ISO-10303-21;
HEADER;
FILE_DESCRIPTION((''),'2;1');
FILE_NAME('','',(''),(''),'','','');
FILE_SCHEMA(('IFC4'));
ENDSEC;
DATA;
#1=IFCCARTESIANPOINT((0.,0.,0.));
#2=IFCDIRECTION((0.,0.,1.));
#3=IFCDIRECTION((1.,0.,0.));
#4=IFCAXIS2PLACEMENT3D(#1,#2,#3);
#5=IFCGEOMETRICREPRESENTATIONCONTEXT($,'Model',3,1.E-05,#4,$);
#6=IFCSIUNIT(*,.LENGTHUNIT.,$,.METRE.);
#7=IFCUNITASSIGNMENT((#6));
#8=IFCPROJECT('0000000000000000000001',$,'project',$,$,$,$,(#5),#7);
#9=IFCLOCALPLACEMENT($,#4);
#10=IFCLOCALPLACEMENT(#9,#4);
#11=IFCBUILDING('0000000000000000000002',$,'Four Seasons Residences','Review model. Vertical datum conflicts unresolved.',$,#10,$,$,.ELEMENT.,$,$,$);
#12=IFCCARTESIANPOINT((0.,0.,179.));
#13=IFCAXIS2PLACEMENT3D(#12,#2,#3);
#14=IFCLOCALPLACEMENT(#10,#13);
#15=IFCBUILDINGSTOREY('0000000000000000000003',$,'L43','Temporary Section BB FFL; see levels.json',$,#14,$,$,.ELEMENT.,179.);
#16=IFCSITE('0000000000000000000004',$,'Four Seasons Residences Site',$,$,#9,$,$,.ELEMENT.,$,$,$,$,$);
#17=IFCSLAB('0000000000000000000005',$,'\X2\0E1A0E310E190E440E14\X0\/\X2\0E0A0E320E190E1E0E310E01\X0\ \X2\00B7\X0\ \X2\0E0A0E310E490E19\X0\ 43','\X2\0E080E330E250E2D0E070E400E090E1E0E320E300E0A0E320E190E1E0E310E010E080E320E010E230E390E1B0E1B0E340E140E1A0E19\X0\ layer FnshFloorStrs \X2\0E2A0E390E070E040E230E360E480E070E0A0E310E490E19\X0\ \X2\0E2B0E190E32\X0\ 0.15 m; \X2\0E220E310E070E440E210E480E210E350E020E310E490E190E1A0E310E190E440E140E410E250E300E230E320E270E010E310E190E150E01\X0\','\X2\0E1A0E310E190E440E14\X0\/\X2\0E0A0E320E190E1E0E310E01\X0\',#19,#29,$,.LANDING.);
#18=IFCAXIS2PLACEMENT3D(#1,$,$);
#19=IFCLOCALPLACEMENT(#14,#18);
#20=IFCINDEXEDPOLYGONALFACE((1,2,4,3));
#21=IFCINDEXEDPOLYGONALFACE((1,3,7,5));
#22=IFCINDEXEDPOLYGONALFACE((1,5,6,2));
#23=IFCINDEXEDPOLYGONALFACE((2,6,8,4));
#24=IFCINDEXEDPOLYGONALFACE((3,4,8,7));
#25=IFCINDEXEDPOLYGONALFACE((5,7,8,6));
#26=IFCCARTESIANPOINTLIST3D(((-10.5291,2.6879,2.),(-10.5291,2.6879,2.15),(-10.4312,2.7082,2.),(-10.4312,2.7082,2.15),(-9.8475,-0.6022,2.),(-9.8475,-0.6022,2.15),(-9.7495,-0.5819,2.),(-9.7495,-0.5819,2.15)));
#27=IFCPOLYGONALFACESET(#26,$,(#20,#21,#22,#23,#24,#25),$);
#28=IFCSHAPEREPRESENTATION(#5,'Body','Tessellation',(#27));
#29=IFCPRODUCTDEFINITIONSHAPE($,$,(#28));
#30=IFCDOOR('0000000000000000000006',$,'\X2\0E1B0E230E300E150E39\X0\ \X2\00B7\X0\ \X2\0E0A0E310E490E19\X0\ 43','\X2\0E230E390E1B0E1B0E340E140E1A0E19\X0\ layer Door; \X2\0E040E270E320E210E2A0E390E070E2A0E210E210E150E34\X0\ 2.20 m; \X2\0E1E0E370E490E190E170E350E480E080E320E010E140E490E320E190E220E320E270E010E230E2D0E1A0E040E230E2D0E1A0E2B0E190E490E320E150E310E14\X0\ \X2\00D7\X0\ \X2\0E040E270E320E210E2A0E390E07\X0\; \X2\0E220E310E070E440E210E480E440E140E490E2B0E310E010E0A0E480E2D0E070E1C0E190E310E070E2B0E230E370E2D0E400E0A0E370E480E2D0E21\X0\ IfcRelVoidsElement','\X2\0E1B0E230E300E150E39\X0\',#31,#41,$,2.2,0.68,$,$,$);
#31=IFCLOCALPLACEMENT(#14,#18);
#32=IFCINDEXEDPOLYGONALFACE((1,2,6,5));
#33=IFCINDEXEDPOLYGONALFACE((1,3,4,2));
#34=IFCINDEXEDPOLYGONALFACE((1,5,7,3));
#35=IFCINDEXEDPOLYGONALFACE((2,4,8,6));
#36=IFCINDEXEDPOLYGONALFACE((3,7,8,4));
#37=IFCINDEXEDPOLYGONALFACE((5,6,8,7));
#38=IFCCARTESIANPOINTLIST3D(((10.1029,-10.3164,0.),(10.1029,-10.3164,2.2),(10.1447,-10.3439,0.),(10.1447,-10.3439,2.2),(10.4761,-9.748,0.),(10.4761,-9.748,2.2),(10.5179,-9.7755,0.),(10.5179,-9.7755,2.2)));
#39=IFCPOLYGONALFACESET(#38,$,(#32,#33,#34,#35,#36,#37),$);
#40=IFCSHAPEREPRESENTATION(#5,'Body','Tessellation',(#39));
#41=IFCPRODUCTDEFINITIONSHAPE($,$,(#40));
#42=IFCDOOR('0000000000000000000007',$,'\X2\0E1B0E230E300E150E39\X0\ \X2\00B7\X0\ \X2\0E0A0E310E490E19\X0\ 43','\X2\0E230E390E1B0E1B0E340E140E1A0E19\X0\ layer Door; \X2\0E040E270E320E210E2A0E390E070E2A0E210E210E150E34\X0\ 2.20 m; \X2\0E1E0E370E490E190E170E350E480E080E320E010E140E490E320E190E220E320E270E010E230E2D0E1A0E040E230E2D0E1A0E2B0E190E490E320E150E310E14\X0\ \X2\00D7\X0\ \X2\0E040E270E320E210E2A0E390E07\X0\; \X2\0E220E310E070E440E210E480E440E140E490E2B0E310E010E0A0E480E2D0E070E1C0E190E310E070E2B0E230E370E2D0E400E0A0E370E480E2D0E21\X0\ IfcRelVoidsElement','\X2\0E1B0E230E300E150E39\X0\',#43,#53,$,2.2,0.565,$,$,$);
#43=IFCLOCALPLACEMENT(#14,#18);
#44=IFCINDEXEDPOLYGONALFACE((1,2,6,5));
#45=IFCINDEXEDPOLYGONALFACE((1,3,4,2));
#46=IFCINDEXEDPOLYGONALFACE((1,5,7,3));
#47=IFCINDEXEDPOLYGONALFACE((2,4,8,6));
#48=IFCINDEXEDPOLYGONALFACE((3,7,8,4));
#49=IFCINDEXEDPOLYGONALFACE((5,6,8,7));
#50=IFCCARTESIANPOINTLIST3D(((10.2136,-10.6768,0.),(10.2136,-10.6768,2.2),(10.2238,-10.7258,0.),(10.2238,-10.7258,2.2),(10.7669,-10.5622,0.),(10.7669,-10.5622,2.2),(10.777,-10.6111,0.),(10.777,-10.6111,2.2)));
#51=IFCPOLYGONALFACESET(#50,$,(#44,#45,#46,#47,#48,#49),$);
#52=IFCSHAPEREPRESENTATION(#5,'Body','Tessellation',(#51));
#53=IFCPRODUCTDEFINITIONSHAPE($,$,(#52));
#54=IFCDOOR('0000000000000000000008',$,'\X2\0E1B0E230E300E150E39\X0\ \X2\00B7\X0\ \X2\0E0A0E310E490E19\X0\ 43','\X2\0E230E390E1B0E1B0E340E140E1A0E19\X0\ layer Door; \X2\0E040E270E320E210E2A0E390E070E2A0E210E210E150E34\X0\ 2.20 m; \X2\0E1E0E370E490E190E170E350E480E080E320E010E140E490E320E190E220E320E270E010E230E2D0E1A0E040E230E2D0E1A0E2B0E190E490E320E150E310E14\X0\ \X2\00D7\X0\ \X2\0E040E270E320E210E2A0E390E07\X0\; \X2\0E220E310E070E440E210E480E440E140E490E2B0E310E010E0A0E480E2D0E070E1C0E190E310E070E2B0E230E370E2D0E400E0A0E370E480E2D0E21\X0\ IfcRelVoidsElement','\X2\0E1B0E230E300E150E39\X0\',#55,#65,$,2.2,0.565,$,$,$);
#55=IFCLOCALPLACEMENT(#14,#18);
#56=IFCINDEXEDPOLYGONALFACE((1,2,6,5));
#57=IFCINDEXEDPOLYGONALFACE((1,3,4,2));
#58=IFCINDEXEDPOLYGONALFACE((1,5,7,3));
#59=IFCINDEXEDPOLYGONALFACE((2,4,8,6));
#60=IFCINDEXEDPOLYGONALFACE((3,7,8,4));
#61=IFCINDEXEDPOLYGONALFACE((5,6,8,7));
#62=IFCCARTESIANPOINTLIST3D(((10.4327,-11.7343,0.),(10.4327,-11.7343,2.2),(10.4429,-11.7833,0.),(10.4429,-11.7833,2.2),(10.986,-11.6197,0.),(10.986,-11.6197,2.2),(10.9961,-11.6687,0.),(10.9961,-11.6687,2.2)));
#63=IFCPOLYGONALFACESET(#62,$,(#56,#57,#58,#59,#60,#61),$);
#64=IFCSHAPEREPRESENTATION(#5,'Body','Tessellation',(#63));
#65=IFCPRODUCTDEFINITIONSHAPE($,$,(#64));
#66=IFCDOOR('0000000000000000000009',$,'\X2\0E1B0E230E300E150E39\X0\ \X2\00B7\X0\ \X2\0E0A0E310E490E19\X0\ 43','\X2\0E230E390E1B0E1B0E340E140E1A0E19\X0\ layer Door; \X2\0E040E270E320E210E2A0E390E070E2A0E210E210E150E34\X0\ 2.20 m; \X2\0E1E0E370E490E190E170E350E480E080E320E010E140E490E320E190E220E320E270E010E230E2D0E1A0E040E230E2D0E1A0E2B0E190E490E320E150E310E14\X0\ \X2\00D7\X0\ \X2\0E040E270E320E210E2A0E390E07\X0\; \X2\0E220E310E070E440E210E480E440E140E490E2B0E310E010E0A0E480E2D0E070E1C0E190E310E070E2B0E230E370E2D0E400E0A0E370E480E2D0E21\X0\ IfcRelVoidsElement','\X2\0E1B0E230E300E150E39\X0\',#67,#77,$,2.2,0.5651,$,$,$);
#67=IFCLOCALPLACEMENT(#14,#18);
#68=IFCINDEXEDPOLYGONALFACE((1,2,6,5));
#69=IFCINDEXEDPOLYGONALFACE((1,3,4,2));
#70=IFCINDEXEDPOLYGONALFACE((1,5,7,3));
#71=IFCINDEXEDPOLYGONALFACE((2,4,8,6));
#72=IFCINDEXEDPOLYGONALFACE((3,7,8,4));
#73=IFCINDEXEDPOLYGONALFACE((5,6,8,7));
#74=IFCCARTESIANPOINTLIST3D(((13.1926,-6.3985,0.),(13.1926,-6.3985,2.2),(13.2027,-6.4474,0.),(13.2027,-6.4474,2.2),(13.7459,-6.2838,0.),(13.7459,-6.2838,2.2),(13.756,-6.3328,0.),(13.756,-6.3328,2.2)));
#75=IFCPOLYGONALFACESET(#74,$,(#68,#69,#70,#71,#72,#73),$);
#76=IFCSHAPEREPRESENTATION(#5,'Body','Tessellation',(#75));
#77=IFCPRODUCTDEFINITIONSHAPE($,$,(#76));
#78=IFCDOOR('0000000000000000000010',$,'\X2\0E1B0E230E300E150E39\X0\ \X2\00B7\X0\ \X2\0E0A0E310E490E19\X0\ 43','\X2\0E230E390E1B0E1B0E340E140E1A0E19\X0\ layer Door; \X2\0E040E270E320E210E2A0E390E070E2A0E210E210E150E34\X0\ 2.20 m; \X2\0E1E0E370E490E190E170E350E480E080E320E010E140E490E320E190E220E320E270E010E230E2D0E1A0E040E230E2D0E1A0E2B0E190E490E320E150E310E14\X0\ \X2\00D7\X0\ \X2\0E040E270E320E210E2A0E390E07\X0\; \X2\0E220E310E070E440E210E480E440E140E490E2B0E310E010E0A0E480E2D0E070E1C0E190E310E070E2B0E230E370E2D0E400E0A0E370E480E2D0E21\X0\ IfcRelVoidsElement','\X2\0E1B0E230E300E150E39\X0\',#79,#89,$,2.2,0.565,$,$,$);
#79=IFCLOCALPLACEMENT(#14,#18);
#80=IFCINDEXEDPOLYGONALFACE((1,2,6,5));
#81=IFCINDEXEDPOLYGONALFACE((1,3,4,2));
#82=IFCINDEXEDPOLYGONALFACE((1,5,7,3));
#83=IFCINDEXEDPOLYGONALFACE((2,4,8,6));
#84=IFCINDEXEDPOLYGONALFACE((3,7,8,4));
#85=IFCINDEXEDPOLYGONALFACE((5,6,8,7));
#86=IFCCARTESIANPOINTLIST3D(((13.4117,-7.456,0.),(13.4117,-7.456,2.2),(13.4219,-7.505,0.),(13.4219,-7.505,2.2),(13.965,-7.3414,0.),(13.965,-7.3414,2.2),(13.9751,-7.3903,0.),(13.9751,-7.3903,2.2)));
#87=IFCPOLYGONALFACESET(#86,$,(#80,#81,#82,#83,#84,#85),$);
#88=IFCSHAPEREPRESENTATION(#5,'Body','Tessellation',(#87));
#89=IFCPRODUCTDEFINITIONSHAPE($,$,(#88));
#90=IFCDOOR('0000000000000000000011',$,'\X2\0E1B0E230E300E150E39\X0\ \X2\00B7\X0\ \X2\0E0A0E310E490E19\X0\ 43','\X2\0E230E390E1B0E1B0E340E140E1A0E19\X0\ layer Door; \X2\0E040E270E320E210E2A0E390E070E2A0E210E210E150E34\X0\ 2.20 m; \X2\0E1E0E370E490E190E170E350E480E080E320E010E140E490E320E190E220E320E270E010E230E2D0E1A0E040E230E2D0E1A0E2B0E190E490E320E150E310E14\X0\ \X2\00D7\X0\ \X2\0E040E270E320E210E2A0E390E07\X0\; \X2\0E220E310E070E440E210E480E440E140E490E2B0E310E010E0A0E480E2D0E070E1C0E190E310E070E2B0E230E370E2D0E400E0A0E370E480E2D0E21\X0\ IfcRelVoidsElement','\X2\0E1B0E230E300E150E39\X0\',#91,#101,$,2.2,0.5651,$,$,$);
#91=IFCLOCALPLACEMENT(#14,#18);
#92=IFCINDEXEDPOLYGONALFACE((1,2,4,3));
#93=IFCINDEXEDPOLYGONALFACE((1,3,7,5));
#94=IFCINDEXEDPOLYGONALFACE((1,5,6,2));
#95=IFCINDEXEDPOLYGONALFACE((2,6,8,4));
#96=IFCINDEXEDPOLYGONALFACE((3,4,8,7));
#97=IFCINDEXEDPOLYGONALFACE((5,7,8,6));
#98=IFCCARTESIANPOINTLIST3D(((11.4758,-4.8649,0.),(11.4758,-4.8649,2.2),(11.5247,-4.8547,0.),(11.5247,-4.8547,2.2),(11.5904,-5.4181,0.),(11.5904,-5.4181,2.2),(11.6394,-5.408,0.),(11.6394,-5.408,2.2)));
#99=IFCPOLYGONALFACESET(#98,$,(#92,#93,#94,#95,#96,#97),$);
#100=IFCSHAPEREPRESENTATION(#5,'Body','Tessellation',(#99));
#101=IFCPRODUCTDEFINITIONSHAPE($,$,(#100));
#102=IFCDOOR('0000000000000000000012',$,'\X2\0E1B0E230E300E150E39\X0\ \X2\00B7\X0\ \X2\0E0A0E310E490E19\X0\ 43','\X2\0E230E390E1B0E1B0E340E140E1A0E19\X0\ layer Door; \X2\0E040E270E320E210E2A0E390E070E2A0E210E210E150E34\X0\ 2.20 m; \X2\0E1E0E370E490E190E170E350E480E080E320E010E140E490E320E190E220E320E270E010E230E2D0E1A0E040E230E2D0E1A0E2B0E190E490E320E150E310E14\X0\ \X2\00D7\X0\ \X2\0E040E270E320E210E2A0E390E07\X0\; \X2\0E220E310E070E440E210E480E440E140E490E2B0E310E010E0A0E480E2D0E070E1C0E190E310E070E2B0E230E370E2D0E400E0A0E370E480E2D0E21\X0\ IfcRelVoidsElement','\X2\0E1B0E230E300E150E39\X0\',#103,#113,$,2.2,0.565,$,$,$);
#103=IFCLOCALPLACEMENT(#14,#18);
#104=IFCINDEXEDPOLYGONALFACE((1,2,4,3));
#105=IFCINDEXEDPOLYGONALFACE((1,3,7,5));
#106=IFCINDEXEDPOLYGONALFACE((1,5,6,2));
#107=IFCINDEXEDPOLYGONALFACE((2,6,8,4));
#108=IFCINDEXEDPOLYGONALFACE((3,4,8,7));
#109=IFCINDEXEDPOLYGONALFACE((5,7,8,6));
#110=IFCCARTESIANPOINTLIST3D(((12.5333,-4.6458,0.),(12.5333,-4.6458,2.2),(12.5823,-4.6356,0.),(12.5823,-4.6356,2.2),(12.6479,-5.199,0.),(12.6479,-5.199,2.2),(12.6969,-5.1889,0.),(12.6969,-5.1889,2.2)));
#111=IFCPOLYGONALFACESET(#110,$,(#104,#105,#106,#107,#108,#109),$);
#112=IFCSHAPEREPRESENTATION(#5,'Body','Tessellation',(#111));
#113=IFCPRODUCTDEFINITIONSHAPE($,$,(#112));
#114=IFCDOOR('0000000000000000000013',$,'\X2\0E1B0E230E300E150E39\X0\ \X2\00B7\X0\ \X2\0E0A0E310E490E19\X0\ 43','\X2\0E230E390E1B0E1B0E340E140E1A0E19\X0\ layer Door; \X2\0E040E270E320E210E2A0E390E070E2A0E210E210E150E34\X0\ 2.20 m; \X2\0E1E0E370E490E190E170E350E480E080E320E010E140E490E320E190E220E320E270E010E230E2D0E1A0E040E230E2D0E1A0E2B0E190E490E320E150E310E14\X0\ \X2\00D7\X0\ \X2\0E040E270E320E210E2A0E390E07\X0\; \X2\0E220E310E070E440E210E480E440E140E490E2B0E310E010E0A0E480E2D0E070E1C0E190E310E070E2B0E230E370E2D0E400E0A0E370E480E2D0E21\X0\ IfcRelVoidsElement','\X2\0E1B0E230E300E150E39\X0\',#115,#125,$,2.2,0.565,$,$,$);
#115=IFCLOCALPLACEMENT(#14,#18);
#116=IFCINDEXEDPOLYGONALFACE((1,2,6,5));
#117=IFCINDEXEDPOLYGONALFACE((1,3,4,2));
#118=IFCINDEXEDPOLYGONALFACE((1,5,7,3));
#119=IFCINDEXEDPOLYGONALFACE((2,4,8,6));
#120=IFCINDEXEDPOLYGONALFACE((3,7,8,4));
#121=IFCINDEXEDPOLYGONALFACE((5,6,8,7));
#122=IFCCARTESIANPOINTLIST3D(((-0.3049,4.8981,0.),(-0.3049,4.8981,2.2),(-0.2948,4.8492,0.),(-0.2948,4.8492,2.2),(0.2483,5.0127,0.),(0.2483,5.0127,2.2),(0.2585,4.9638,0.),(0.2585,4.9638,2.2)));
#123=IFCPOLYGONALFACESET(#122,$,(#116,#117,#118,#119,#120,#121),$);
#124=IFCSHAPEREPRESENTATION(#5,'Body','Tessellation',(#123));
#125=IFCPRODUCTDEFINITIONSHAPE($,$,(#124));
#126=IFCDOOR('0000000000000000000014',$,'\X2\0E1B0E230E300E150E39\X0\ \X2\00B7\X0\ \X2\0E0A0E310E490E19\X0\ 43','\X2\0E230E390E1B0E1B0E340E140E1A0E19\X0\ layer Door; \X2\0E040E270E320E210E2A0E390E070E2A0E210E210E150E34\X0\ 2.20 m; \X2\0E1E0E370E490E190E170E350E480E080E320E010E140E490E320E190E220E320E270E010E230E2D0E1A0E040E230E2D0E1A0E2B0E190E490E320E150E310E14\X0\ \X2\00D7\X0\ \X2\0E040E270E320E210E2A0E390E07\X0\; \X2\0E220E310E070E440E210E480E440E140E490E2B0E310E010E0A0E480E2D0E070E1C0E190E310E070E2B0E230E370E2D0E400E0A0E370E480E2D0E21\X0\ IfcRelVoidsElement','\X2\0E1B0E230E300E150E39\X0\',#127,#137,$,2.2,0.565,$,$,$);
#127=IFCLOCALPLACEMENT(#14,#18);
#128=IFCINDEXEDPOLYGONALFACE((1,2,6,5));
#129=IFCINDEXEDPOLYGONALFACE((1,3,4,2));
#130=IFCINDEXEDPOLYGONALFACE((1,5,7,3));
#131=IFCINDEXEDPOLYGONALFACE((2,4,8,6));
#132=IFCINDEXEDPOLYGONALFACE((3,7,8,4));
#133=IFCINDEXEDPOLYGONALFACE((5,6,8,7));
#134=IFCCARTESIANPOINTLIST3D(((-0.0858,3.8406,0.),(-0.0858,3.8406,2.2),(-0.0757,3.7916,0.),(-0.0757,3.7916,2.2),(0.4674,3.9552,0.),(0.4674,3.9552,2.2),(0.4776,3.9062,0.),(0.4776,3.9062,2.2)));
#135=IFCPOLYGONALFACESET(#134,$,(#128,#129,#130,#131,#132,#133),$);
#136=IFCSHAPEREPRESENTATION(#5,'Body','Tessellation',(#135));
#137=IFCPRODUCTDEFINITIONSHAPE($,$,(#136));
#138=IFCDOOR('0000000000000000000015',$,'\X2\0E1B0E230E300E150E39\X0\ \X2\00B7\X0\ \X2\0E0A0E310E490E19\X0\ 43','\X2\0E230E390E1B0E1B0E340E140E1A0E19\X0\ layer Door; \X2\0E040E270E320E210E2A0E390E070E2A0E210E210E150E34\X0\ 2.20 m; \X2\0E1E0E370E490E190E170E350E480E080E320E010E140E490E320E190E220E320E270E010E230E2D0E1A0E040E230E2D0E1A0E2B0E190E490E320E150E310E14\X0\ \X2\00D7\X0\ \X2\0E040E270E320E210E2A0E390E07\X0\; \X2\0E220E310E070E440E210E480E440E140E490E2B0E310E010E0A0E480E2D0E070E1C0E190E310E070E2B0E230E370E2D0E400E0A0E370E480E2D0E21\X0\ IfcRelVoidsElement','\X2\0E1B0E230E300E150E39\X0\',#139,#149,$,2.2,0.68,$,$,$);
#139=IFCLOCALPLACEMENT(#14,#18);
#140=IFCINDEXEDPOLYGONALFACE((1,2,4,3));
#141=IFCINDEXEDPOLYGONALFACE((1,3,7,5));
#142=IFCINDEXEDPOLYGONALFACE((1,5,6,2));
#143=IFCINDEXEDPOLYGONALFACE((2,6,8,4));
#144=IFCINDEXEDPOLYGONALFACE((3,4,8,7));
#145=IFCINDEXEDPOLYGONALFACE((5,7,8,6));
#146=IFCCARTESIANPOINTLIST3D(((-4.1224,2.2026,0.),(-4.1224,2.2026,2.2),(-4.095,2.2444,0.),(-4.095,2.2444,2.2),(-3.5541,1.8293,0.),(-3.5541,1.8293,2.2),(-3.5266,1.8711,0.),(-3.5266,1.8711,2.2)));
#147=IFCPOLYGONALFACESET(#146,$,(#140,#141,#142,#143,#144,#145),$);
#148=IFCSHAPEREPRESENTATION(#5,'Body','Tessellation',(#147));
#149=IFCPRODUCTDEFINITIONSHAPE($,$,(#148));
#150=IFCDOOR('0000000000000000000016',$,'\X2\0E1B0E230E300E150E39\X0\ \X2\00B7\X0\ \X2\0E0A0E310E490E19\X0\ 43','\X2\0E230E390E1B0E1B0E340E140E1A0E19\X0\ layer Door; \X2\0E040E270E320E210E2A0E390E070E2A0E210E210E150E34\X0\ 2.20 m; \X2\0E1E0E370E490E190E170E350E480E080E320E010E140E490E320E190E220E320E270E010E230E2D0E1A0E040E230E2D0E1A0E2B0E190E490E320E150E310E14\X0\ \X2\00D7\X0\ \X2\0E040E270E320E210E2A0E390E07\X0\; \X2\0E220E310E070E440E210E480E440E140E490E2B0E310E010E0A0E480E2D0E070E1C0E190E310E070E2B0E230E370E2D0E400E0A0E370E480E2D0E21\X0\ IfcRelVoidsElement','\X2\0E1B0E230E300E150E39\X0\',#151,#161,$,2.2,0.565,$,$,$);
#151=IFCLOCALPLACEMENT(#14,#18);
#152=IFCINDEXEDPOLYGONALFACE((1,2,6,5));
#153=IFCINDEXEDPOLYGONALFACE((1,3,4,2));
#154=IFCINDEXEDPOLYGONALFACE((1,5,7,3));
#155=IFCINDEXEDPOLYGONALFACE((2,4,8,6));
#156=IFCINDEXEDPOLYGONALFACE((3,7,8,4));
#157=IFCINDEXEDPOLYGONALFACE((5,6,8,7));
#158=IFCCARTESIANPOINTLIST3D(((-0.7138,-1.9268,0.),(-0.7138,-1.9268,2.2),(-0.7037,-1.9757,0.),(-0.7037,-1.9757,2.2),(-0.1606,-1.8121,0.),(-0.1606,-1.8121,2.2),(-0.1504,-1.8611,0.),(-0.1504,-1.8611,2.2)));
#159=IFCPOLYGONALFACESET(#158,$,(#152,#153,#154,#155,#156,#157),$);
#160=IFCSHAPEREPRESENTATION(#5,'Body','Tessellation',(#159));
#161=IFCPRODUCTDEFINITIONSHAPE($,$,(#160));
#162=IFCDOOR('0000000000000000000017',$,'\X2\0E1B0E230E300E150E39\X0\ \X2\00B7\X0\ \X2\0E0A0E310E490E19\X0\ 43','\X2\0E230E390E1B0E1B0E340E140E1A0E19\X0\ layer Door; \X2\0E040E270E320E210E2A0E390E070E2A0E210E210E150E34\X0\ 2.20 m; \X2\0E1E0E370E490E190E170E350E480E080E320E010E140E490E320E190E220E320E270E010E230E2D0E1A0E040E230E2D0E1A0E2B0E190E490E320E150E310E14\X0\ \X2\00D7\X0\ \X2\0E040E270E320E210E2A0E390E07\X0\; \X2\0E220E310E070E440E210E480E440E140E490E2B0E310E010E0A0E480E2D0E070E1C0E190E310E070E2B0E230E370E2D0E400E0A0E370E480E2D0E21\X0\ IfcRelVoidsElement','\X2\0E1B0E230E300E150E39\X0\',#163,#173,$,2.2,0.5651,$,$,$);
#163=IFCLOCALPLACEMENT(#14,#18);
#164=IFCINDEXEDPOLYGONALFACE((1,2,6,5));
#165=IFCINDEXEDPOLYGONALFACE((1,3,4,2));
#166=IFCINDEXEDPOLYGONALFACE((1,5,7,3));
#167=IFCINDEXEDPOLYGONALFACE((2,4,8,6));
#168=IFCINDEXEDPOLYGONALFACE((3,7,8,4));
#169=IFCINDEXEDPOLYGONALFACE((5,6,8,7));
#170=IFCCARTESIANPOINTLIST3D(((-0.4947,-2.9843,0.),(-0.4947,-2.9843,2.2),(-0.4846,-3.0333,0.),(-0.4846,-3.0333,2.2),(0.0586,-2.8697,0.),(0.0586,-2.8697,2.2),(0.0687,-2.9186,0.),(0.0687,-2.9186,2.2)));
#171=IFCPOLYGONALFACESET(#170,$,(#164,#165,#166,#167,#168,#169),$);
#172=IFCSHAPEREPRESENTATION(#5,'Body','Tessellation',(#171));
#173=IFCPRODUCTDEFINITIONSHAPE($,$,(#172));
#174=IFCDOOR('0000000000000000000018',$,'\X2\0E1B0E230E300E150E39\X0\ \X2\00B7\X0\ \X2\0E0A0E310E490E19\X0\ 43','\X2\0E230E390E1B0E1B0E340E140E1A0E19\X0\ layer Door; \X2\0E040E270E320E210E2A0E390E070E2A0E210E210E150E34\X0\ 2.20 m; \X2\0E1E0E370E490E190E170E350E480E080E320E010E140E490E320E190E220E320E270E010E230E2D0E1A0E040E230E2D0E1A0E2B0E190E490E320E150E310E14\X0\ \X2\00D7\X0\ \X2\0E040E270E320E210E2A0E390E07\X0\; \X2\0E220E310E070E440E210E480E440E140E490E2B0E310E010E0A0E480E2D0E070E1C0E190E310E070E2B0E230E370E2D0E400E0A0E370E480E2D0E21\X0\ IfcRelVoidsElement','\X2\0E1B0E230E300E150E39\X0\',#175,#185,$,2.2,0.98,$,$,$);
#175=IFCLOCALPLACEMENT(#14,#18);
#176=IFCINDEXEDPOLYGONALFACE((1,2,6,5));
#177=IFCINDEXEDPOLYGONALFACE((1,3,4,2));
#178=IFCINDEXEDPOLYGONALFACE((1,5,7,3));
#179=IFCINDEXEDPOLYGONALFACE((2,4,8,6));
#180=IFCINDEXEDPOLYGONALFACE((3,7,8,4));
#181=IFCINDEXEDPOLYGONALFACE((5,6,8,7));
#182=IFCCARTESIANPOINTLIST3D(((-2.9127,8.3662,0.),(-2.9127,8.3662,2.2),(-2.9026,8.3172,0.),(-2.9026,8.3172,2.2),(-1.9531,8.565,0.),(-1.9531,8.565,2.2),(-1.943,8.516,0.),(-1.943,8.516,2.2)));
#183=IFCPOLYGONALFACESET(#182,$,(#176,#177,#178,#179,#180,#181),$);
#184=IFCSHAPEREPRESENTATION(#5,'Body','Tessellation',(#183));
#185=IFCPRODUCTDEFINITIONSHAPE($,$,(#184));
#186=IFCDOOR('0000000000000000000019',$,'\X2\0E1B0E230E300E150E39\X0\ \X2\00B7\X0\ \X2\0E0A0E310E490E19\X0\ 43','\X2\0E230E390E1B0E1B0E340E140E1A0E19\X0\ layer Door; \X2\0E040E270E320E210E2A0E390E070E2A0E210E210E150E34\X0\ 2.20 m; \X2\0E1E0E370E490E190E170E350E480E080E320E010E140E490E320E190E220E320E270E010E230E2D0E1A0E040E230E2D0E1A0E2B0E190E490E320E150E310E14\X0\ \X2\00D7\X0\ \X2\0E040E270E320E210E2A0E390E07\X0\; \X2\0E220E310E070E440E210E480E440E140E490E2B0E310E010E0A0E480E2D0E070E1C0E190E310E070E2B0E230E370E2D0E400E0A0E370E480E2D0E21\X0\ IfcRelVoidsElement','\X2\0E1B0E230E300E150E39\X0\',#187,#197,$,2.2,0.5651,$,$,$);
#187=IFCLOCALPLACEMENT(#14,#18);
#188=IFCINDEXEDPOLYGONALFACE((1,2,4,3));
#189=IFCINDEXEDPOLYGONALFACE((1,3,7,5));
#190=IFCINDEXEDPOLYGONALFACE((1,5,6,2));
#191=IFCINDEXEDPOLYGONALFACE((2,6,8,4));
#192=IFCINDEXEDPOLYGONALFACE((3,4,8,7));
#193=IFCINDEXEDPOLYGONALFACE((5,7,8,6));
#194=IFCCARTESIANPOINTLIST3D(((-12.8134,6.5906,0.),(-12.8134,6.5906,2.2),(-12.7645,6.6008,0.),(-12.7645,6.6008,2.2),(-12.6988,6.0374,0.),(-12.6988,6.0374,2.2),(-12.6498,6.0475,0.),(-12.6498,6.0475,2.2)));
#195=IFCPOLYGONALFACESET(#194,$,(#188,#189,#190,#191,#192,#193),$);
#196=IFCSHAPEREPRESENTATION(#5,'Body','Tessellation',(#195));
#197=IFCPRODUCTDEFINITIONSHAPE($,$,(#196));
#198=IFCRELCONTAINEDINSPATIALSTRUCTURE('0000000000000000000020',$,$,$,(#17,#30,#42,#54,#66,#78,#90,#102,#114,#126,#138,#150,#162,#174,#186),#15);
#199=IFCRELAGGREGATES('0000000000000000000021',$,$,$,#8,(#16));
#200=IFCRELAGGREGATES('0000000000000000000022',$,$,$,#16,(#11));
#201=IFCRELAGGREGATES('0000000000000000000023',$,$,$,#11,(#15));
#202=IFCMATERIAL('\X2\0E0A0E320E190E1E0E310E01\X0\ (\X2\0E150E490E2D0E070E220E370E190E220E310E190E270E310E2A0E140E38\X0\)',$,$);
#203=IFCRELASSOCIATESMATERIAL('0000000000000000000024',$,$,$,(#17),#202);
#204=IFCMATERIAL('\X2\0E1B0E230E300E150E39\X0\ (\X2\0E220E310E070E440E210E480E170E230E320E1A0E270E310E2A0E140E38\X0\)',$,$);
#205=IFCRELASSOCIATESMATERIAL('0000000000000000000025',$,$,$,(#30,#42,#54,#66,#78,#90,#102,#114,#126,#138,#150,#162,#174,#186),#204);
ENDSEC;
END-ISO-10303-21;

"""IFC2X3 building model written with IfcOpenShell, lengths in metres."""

from ifc_helpers import new_model, si_unit, frame, origin_with_axes, place, context, project, spatial, polyline, outline, extrude, material, element, save


model = new_model("IFC2X3")

# Units and contexts
model_context = context("Model", 3, precision=1e-05, world=origin_with_axes())
ifc_project = project(units=[si_unit("LENGTHUNIT", "METRE")], contexts=[model_context])

# Site, building, storey
site_placement = place(None, origin_with_axes())
site = spatial("IfcSite", under=ifc_project, at=site_placement, Name="Four Seasons Residences Site", CompositionType="ELEMENT")
building_placement = place(site_placement, origin_with_axes())
building = spatial("IfcBuilding", under=site, at=building_placement, Name="Four Seasons Residences", Description="Review model. Vertical datum conflicts unresolved.", CompositionType="ELEMENT")
storey_placement = place(building_placement, frame((0.0, 0.0, 179.0), z_axis=(0.0, 0.0, 1.0), x_axis=(1.0, 0.0, 0.0)))
storey = spatial("IfcBuildingStorey", under=building, at=storey_placement, Name="L43", Description="Temporary Section BB FFL; see levels.json", CompositionType="ELEMENT", Elevation=179.0)

# Slab
ifc_material_1 = material(Name="ชานพัก (ต้องยืนยันวัสดุ)")
slab_placement = place(storey_placement, origin_with_axes())
element("IfcSlab", 1, at=slab_placement, inside=storey, material=ifc_material_1, Name="บันได/ชานพัก · ชั้น 43", Description="จำลองเฉพาะชานพักจากรูปปิดบน layer FnshFloorStrs สูงครึ่งชั้น หนา 0.15 m; ยังไม่มีขั้นบันไดและราวกันตก", ObjectType="บันได/ชานพัก", PredefinedType="LANDING", context=model_context, shape_type="SweptSolid", body=[
    extrude(outline(polyline([(-10.5291, 2.6879), (-10.4312, 2.7082), (-9.7495, -0.5819), (-9.8475, -0.6022), (-10.5291, 2.6879)])), frame((0.0, 0.0, 2.0), z_axis=(0.0, 0.0, 1.0), x_axis=(1.0, 0.0, 0.0)), (0.0, 0.0, 1.0), 0.15),
])

# Doors
ifc_material_2 = material(Name="ประตู (ยังไม่ทราบวัสดุ)")
door_1_placement = place(storey_placement, origin_with_axes())
element("IfcDoor", 2, at=door_1_placement, inside=storey, material=ifc_material_2, Name="ประตู · ชั้น 43", Description="รูปปิดบน layer Door; ความสูงสมมติ 2.20 m; พื้นที่จากด้านยาวกรอบครอบหน้าตัด × ความสูง; ยังไม่ได้หักช่องผนังหรือเชื่อม IfcRelVoidsElement", ObjectType="ประตู", OverallHeight=2.2, OverallWidth=0.68, context=model_context, shape_type="SweptSolid", body=[
    extrude(outline(polyline([(10.5179, -9.7755), (10.1447, -10.3439), (10.1029, -10.3164), (10.4761, -9.748), (10.5179, -9.7755)])), origin_with_axes(), (0.0, 0.0, 1.0), 2.2),
])
door_2_placement = place(storey_placement, origin_with_axes())
element("IfcDoor", 3, at=door_2_placement, inside=storey, material=ifc_material_2, Name="ประตู · ชั้น 43", Description="รูปปิดบน layer Door; ความสูงสมมติ 2.20 m; พื้นที่จากด้านยาวกรอบครอบหน้าตัด × ความสูง; ยังไม่ได้หักช่องผนังหรือเชื่อม IfcRelVoidsElement", ObjectType="ประตู", OverallHeight=2.2, OverallWidth=0.565, context=model_context, shape_type="SweptSolid", body=[
    extrude(outline(polyline([(10.7669, -10.5622), (10.2136, -10.6768), (10.2238, -10.7258), (10.777, -10.6111), (10.7669, -10.5622)])), origin_with_axes(), (0.0, 0.0, 1.0), 2.2),
])
door_3_placement = place(storey_placement, origin_with_axes())
element("IfcDoor", 4, at=door_3_placement, inside=storey, material=ifc_material_2, Name="ประตู · ชั้น 43", Description="รูปปิดบน layer Door; ความสูงสมมติ 2.20 m; พื้นที่จากด้านยาวกรอบครอบหน้าตัด × ความสูง; ยังไม่ได้หักช่องผนังหรือเชื่อม IfcRelVoidsElement", ObjectType="ประตู", OverallHeight=2.2, OverallWidth=0.565, context=model_context, shape_type="SweptSolid", body=[
    extrude(outline(polyline([(10.9961, -11.6687), (10.4429, -11.7833), (10.4327, -11.7343), (10.986, -11.6197), (10.9961, -11.6687)])), origin_with_axes(), (0.0, 0.0, 1.0), 2.2),
])
door_4_placement = place(storey_placement, origin_with_axes())
element("IfcDoor", 5, at=door_4_placement, inside=storey, material=ifc_material_2, Name="ประตู · ชั้น 43", Description="รูปปิดบน layer Door; ความสูงสมมติ 2.20 m; พื้นที่จากด้านยาวกรอบครอบหน้าตัด × ความสูง; ยังไม่ได้หักช่องผนังหรือเชื่อม IfcRelVoidsElement", ObjectType="ประตู", OverallHeight=2.2, OverallWidth=0.5651, context=model_context, shape_type="SweptSolid", body=[
    extrude(outline(polyline([(13.1926, -6.3985), (13.7459, -6.2838), (13.756, -6.3328), (13.2027, -6.4474), (13.1926, -6.3985)])), origin_with_axes(), (0.0, 0.0, 1.0), 2.2),
])
door_5_placement = place(storey_placement, origin_with_axes())
element("IfcDoor", 6, at=door_5_placement, inside=storey, material=ifc_material_2, Name="ประตู · ชั้น 43", Description="รูปปิดบน layer Door; ความสูงสมมติ 2.20 m; พื้นที่จากด้านยาวกรอบครอบหน้าตัด × ความสูง; ยังไม่ได้หักช่องผนังหรือเชื่อม IfcRelVoidsElement", ObjectType="ประตู", OverallHeight=2.2, OverallWidth=0.565, context=model_context, shape_type="SweptSolid", body=[
    extrude(outline(polyline([(13.4219, -7.505), (13.9751, -7.3903), (13.965, -7.3414), (13.4117, -7.456), (13.4219, -7.505)])), origin_with_axes(), (0.0, 0.0, 1.0), 2.2),
])
door_6_placement = place(storey_placement, origin_with_axes())
element("IfcDoor", 7, at=door_6_placement, inside=storey, material=ifc_material_2, Name="ประตู · ชั้น 43", Description="รูปปิดบน layer Door; ความสูงสมมติ 2.20 m; พื้นที่จากด้านยาวกรอบครอบหน้าตัด × ความสูง; ยังไม่ได้หักช่องผนังหรือเชื่อม IfcRelVoidsElement", ObjectType="ประตู", OverallHeight=2.2, OverallWidth=0.5651, context=model_context, shape_type="SweptSolid", body=[
    extrude(outline(polyline([(11.4758, -4.8649), (11.5904, -5.4181), (11.6394, -5.408), (11.5247, -4.8547), (11.4758, -4.8649)])), origin_with_axes(), (0.0, 0.0, 1.0), 2.2),
])
door_7_placement = place(storey_placement, origin_with_axes())
element("IfcDoor", 8, at=door_7_placement, inside=storey, material=ifc_material_2, Name="ประตู · ชั้น 43", Description="รูปปิดบน layer Door; ความสูงสมมติ 2.20 m; พื้นที่จากด้านยาวกรอบครอบหน้าตัด × ความสูง; ยังไม่ได้หักช่องผนังหรือเชื่อม IfcRelVoidsElement", ObjectType="ประตู", OverallHeight=2.2, OverallWidth=0.565, context=model_context, shape_type="SweptSolid", body=[
    extrude(outline(polyline([(12.5823, -4.6356), (12.6969, -5.1889), (12.6479, -5.199), (12.5333, -4.6458), (12.5823, -4.6356)])), origin_with_axes(), (0.0, 0.0, 1.0), 2.2),
])
door_8_placement = place(storey_placement, origin_with_axes())
element("IfcDoor", 9, at=door_8_placement, inside=storey, material=ifc_material_2, Name="ประตู · ชั้น 43", Description="รูปปิดบน layer Door; ความสูงสมมติ 2.20 m; พื้นที่จากด้านยาวกรอบครอบหน้าตัด × ความสูง; ยังไม่ได้หักช่องผนังหรือเชื่อม IfcRelVoidsElement", ObjectType="ประตู", OverallHeight=2.2, OverallWidth=0.565, context=model_context, shape_type="SweptSolid", body=[
    extrude(outline(polyline([(-0.3049, 4.8981), (0.2483, 5.0127), (0.2585, 4.9638), (-0.2948, 4.8492), (-0.3049, 4.8981)])), origin_with_axes(), (0.0, 0.0, 1.0), 2.2),
])
door_9_placement = place(storey_placement, origin_with_axes())
element("IfcDoor", 10, at=door_9_placement, inside=storey, material=ifc_material_2, Name="ประตู · ชั้น 43", Description="รูปปิดบน layer Door; ความสูงสมมติ 2.20 m; พื้นที่จากด้านยาวกรอบครอบหน้าตัด × ความสูง; ยังไม่ได้หักช่องผนังหรือเชื่อม IfcRelVoidsElement", ObjectType="ประตู", OverallHeight=2.2, OverallWidth=0.565, context=model_context, shape_type="SweptSolid", body=[
    extrude(outline(polyline([(-0.0757, 3.7916), (0.4776, 3.9062), (0.4674, 3.9552), (-0.0858, 3.8406), (-0.0757, 3.7916)])), origin_with_axes(), (0.0, 0.0, 1.0), 2.2),
])
door_10_placement = place(storey_placement, origin_with_axes())
element("IfcDoor", 11, at=door_10_placement, inside=storey, material=ifc_material_2, Name="ประตู · ชั้น 43", Description="รูปปิดบน layer Door; ความสูงสมมติ 2.20 m; พื้นที่จากด้านยาวกรอบครอบหน้าตัด × ความสูง; ยังไม่ได้หักช่องผนังหรือเชื่อม IfcRelVoidsElement", ObjectType="ประตู", OverallHeight=2.2, OverallWidth=0.68, context=model_context, shape_type="SweptSolid", body=[
    extrude(outline(polyline([(-3.5541, 1.8293), (-4.1224, 2.2026), (-4.095, 2.2444), (-3.5266, 1.8711), (-3.5541, 1.8293)])), origin_with_axes(), (0.0, 0.0, 1.0), 2.2),
])
door_11_placement = place(storey_placement, origin_with_axes())
element("IfcDoor", 12, at=door_11_placement, inside=storey, material=ifc_material_2, Name="ประตู · ชั้น 43", Description="รูปปิดบน layer Door; ความสูงสมมติ 2.20 m; พื้นที่จากด้านยาวกรอบครอบหน้าตัด × ความสูง; ยังไม่ได้หักช่องผนังหรือเชื่อม IfcRelVoidsElement", ObjectType="ประตู", OverallHeight=2.2, OverallWidth=0.565, context=model_context, shape_type="SweptSolid", body=[
    extrude(outline(polyline([(-0.1606, -1.8121), (-0.7138, -1.9268), (-0.7037, -1.9757), (-0.1504, -1.8611), (-0.1606, -1.8121)])), origin_with_axes(), (0.0, 0.0, 1.0), 2.2),
])
door_12_placement = place(storey_placement, origin_with_axes())
element("IfcDoor", 13, at=door_12_placement, inside=storey, material=ifc_material_2, Name="ประตู · ชั้น 43", Description="รูปปิดบน layer Door; ความสูงสมมติ 2.20 m; พื้นที่จากด้านยาวกรอบครอบหน้าตัด × ความสูง; ยังไม่ได้หักช่องผนังหรือเชื่อม IfcRelVoidsElement", ObjectType="ประตู", OverallHeight=2.2, OverallWidth=0.5651, context=model_context, shape_type="SweptSolid", body=[
    extrude(outline(polyline([(0.0687, -2.9186), (-0.4846, -3.0333), (-0.4947, -2.9843), (0.0586, -2.8697), (0.0687, -2.9186)])), origin_with_axes(), (0.0, 0.0, 1.0), 2.2),
])
door_13_placement = place(storey_placement, origin_with_axes())
element("IfcDoor", 14, at=door_13_placement, inside=storey, material=ifc_material_2, Name="ประตู · ชั้น 43", Description="รูปปิดบน layer Door; ความสูงสมมติ 2.20 m; พื้นที่จากด้านยาวกรอบครอบหน้าตัด × ความสูง; ยังไม่ได้หักช่องผนังหรือเชื่อม IfcRelVoidsElement", ObjectType="ประตู", OverallHeight=2.2, OverallWidth=0.98, context=model_context, shape_type="SweptSolid", body=[
    extrude(outline(polyline([(-2.9127, 8.3662), (-2.9026, 8.3172), (-1.943, 8.516), (-1.9531, 8.565), (-2.9127, 8.3662)])), origin_with_axes(), (0.0, 0.0, 1.0), 2.2),
])
door_14_placement = place(storey_placement, origin_with_axes())
element("IfcDoor", 15, at=door_14_placement, inside=storey, material=ifc_material_2, Name="ประตู · ชั้น 43", Description="รูปปิดบน layer Door; ความสูงสมมติ 2.20 m; พื้นที่จากด้านยาวกรอบครอบหน้าตัด × ความสูง; ยังไม่ได้หักช่องผนังหรือเชื่อม IfcRelVoidsElement", ObjectType="ประตู", OverallHeight=2.2, OverallWidth=0.5651, context=model_context, shape_type="SweptSolid", body=[
    extrude(outline(polyline([(-12.6988, 6.0374), (-12.8134, 6.5906), (-12.7645, 6.6008), (-12.6498, 6.0475), (-12.6988, 6.0374)])), origin_with_axes(), (0.0, 0.0, 1.0), 2.2),
])

save(model, "model.ifc")
